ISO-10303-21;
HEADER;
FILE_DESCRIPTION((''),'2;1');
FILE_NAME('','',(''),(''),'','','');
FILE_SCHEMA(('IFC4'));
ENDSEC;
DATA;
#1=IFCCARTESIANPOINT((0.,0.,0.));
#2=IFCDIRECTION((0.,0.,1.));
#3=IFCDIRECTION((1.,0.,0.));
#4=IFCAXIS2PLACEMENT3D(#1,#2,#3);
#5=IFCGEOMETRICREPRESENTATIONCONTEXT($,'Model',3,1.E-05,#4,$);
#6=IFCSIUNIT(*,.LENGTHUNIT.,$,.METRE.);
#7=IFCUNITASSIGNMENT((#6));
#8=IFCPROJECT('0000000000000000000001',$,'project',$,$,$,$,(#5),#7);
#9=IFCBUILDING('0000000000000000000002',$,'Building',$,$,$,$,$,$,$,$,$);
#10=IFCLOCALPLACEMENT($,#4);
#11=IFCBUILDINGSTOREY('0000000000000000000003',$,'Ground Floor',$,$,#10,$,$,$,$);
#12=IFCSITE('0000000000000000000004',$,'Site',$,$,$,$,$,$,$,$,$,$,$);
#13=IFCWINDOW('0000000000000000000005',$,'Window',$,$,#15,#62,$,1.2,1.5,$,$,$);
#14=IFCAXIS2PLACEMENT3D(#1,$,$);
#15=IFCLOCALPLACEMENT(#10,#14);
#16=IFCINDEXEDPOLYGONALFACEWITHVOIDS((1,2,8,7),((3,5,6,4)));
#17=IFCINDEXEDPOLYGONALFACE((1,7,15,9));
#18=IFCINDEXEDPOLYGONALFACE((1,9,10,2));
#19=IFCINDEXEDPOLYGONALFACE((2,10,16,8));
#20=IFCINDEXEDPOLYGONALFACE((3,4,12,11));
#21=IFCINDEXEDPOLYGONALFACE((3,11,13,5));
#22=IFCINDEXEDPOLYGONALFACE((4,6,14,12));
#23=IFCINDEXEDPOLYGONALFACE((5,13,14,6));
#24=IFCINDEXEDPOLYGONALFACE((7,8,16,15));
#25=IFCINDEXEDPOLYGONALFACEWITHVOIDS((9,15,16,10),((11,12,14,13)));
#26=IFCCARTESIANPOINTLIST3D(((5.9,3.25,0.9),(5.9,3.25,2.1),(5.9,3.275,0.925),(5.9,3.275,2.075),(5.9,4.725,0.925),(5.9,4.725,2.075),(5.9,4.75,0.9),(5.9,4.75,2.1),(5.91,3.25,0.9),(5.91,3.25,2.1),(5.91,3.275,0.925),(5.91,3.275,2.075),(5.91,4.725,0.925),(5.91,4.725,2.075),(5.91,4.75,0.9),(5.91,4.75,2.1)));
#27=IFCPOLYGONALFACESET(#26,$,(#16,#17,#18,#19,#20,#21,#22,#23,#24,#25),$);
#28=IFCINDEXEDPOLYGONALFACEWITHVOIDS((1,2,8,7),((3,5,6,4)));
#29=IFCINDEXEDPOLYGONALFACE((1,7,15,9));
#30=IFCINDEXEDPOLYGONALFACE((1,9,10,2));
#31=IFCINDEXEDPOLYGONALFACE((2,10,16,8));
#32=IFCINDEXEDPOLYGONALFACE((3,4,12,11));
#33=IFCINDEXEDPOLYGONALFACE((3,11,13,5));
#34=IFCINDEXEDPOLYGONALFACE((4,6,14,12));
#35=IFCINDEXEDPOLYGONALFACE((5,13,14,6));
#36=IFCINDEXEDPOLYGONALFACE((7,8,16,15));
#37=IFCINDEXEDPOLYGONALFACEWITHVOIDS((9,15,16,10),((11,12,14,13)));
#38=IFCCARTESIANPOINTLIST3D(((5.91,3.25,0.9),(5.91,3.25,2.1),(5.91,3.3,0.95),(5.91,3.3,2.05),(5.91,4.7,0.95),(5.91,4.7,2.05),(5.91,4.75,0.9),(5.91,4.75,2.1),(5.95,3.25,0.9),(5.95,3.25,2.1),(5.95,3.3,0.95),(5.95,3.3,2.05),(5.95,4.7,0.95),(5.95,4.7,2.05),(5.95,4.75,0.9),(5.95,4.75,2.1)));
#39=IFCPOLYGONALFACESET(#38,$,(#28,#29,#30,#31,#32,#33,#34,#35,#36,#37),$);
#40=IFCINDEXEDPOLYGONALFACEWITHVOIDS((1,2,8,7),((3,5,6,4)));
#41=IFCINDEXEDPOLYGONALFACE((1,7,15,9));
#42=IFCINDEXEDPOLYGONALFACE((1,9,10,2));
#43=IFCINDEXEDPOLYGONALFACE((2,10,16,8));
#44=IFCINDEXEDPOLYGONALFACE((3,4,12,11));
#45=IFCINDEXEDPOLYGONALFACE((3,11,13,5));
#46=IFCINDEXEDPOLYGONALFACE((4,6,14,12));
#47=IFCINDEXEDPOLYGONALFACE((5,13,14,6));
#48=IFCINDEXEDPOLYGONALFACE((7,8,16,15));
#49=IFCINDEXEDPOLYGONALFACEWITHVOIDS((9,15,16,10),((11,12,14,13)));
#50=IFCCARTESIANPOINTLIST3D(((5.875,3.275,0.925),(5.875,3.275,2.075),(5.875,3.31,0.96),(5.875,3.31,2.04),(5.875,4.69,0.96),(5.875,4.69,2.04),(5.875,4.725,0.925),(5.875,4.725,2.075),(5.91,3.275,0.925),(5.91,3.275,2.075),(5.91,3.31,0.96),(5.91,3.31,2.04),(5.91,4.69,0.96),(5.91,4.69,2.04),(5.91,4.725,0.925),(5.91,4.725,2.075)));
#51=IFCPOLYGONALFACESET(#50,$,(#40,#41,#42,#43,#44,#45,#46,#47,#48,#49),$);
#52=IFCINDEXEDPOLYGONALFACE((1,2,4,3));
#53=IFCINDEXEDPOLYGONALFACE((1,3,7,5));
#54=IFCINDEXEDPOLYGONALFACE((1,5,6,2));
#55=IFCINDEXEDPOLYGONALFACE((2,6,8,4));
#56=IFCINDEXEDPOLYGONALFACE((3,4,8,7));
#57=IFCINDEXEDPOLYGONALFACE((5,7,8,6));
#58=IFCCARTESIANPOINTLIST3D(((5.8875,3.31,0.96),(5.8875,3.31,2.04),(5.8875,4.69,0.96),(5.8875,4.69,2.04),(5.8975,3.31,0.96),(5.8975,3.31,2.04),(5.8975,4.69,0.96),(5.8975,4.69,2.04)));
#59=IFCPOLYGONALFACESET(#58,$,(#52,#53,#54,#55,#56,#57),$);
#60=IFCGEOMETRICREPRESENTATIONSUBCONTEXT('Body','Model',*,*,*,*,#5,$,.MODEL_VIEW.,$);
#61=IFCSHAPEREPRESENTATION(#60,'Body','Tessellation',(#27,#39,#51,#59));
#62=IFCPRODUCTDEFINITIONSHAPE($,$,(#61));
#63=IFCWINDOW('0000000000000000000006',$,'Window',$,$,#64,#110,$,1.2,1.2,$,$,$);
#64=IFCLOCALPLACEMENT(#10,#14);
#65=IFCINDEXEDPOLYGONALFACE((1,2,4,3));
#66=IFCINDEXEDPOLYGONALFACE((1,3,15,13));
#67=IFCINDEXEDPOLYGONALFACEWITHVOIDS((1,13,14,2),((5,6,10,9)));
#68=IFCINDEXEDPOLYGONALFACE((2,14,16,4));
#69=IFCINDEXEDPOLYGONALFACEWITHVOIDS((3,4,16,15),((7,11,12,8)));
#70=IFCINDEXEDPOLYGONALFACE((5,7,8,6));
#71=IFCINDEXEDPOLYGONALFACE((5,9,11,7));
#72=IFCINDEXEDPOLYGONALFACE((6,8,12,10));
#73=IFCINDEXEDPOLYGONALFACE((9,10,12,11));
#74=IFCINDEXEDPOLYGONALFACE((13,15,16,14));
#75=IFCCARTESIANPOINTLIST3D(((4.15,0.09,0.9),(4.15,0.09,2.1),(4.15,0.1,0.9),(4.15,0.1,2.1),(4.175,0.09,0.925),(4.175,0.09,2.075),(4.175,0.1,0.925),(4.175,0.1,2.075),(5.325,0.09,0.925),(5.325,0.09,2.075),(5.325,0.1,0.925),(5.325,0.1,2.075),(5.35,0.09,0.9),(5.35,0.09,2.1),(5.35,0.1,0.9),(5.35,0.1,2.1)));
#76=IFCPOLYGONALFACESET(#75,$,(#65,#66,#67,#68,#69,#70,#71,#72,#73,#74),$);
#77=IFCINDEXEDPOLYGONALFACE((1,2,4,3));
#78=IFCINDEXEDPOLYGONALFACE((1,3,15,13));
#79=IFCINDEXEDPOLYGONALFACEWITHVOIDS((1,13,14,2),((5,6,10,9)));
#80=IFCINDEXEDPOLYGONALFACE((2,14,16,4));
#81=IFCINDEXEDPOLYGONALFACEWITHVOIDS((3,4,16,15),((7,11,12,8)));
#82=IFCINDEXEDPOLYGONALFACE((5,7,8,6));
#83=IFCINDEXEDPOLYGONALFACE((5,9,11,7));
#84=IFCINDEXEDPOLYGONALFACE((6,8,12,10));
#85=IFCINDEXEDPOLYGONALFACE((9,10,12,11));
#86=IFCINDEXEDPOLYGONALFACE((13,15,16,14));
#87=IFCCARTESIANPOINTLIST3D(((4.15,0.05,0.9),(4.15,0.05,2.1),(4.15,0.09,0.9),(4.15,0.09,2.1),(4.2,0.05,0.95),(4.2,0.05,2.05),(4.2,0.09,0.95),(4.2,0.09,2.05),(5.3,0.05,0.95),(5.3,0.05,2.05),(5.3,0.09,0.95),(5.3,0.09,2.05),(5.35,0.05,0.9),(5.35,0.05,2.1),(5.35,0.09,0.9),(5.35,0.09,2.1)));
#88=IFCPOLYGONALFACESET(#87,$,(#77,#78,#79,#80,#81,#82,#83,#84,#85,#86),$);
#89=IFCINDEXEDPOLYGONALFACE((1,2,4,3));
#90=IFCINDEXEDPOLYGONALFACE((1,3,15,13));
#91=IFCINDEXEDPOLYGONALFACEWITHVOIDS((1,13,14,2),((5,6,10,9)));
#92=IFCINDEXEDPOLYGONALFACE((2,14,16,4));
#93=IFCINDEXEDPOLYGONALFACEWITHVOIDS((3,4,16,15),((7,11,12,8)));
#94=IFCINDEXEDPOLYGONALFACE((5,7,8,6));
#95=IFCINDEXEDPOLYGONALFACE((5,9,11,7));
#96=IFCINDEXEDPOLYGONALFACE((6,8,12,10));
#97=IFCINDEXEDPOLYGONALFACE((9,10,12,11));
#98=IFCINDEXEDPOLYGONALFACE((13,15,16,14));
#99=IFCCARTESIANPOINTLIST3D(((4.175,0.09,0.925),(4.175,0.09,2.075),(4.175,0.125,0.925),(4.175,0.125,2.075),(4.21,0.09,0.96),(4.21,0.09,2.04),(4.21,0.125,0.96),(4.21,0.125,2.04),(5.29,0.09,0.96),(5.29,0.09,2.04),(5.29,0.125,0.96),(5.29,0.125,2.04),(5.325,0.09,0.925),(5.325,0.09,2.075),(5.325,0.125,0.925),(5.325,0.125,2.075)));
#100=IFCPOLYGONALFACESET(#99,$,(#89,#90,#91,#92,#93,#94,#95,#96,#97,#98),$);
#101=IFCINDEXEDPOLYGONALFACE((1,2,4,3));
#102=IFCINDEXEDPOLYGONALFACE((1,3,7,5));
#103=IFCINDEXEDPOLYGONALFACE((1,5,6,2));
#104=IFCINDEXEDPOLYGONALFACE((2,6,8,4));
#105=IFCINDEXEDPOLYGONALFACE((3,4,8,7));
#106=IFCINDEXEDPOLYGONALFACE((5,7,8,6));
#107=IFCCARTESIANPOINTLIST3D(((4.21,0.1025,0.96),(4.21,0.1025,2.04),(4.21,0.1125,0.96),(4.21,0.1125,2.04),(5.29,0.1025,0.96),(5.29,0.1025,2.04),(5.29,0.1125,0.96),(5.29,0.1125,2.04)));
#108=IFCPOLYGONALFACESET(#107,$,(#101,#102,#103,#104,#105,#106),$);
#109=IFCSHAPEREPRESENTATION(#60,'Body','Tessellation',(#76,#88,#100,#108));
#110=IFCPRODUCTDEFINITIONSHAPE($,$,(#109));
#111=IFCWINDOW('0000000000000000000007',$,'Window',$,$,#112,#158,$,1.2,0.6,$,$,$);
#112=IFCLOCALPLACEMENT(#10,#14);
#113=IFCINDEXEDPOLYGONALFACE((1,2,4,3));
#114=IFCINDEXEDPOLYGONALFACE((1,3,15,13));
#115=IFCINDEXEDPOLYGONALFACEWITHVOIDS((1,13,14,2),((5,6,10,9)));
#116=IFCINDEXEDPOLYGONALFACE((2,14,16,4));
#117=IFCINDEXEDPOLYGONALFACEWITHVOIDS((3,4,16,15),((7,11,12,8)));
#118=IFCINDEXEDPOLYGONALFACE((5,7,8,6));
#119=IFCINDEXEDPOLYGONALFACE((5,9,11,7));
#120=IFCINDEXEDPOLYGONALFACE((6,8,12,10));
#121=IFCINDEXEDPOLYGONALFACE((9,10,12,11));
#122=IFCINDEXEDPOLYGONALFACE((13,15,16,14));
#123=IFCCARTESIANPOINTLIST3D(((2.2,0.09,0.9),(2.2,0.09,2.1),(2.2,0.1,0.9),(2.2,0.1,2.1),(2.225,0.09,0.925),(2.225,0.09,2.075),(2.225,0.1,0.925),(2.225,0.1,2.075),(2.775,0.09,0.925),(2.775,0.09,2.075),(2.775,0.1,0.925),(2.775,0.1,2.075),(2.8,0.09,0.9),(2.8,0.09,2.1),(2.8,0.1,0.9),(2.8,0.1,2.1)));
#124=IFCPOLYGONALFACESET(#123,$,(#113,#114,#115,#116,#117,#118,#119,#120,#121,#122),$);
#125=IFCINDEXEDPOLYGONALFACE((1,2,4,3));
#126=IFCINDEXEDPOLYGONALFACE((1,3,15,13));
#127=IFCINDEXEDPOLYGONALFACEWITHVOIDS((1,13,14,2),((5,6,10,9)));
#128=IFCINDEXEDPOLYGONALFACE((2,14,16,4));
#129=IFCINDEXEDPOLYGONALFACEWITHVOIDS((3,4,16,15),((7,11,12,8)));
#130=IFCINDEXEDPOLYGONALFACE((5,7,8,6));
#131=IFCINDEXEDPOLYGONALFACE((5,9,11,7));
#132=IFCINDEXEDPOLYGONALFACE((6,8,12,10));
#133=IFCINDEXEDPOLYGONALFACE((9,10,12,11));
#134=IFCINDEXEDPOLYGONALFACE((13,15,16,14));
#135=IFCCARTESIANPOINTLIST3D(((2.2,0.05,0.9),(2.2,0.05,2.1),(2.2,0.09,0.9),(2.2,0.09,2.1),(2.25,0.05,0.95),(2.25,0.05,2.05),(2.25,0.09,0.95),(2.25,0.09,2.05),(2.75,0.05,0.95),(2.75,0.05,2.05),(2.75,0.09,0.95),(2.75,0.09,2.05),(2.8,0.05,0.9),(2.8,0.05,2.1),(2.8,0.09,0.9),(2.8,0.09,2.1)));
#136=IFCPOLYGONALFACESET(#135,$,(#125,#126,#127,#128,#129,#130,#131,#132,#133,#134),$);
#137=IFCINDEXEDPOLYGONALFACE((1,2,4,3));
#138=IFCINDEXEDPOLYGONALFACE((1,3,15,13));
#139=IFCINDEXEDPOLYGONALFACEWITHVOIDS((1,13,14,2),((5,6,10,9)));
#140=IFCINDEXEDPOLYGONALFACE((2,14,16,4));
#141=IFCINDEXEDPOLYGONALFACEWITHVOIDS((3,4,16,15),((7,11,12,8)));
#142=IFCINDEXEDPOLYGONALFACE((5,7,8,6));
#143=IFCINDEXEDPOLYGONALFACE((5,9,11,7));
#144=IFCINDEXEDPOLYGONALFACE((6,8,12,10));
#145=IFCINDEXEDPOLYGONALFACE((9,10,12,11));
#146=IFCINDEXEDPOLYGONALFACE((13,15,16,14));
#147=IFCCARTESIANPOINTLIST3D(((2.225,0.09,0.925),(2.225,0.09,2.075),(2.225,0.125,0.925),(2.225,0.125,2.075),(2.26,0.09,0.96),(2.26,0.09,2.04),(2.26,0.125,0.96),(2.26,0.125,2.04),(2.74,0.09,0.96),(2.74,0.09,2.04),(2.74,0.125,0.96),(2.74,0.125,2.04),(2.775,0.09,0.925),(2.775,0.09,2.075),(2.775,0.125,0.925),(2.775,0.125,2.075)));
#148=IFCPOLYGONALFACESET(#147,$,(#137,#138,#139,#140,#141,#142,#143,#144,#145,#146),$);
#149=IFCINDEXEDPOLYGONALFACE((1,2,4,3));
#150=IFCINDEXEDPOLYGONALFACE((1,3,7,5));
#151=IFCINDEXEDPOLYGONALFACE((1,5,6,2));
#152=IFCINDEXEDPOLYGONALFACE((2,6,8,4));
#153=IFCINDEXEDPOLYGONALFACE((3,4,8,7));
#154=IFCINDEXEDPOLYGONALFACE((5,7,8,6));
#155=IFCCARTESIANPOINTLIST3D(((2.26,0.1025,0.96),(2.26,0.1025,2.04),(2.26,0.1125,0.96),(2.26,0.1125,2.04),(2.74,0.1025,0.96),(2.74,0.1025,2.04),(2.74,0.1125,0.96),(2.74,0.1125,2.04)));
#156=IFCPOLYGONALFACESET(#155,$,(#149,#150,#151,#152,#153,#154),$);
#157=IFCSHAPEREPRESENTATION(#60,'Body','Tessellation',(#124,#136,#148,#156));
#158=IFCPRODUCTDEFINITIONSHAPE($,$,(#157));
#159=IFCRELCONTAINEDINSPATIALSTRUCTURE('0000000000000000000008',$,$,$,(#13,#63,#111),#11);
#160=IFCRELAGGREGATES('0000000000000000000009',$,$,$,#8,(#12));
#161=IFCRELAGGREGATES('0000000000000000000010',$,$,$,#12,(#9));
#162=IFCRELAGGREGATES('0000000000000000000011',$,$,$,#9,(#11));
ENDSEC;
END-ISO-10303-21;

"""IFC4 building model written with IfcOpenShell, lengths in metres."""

from ifc_helpers import new_model, si_unit, frame, origin_with_axes, place, context, subcontext, project, spatial, line, indexed_curve, outline, extrude, element, save


model = new_model("IFC4")

# Units and contexts
model_context = context("Model", 3, precision=1e-05, world=origin_with_axes())
body_context = subcontext(model_context, "Body", "Model", "MODEL_VIEW")
ifc_project = project(units=[si_unit("LENGTHUNIT", "METRE")], contexts=[model_context])

# Site, building, storey
site = spatial("IfcSite", under=ifc_project, Name="Site")
building = spatial("IfcBuilding", under=site, Name="Building")
storey_placement = place(None, origin_with_axes())
storey = spatial("IfcBuildingStorey", under=building, at=storey_placement, Name="Ground Floor")

# Windows
for number, where, z_axis, x_axis, name in (
    (1, (6.0, 3.25, 0.9), (0.0, 0.0, 1.0), (0.0, 1.0, 0.0), "Window"),
):
    element("IfcWindow", number, at=place(storey_placement, frame(where, z_axis=z_axis, x_axis=x_axis)), inside=storey, Name=name, OverallHeight=1.2, OverallWidth=1.5, context=body_context, shape_type="SweptSolid", body=[
        extrude(outline(indexed_curve([(0.0, 0.0), (1.5, 0.0), (1.5, 1.2), (0.0, 1.2)], segments=[line(1, 2, 3, 4, 1)]), holes=[indexed_curve([(0.025, 0.025), (1.475, 0.025), (1.475, 1.175), (0.025, 1.175)], segments=[line(1, 2, 3, 4, 1)])]), frame((0.0, 0.09, 0.0), z_axis=(0.0, -1.0, 0.0), x_axis=(1.0, 0.0, 0.0)), (0.0, 0.0, -1.0), 0.01),
        extrude(outline(indexed_curve([(0.0, 0.0), (1.5, 0.0), (1.5, 1.2), (0.0, 1.2)], segments=[line(1, 2, 3, 4, 1)]), holes=[indexed_curve([(0.05, 0.05), (1.45, 0.05), (1.45, 1.15), (0.05, 1.15)], segments=[line(1, 2, 3, 4, 1)])]), frame((0.0, 0.05, 0.0), z_axis=(0.0, -1.0, 0.0), x_axis=(1.0, 0.0, 0.0)), (0.0, 0.0, -1.0), 0.04),
        extrude(outline(indexed_curve([(0.0, 0.0), (1.45, 0.0), (1.45, 1.15), (0.0, 1.15)], segments=[line(1, 2, 3, 4, 1)]), holes=[indexed_curve([(0.035, 0.035), (1.415, 0.035), (1.415, 1.115), (0.035, 1.115)], segments=[line(1, 2, 3, 4, 1)])]), frame((0.025, 0.09, 0.025), z_axis=(0.0, -1.0, 0.0), x_axis=(1.0, 0.0, 0.0)), (0.0, 0.0, -1.0), 0.035),
        extrude(outline(indexed_curve([(0.035, 0.035), (1.415, 0.035), (1.415, 1.115), (0.035, 1.115)], segments=[line(1, 2, 3, 4, 1)])), frame((0.025, 0.1025, 0.025), z_axis=(0.0, -1.0, 0.0), x_axis=(1.0, 0.0, 0.0)), (0.0, 0.0, -1.0), 0.01),
    ])
window_1_placement = place(storey_placement, frame((4.15, 0.0, 0.9), z_axis=(0.0, 0.0, 1.0), x_axis=(1.0, 0.0, 0.0)))
element("IfcWindow", 2, at=window_1_placement, inside=storey, Name="Window", OverallHeight=1.2, OverallWidth=1.2, context=body_context, shape_type="SweptSolid", body=[
    extrude(outline(indexed_curve([(0.0, 0.0), (1.2, 0.0), (1.2, 1.2), (0.0, 1.2)], segments=[line(1, 2, 3, 4, 1)]), holes=[indexed_curve([(0.025, 0.025), (1.175, 0.025), (1.175, 1.175), (0.025, 1.175)], segments=[line(1, 2, 3, 4, 1)])]), frame((0.0, 0.09, 0.0), z_axis=(0.0, -1.0, 0.0), x_axis=(1.0, 0.0, 0.0)), (0.0, 0.0, -1.0), 0.01),
    extrude(outline(indexed_curve([(0.0, 0.0), (1.2, 0.0), (1.2, 1.2), (0.0, 1.2)], segments=[line(1, 2, 3, 4, 1)]), holes=[indexed_curve([(0.05, 0.05), (1.15, 0.05), (1.15, 1.15), (0.05, 1.15)], segments=[line(1, 2, 3, 4, 1)])]), frame((0.0, 0.05, 0.0), z_axis=(0.0, -1.0, 0.0), x_axis=(1.0, 0.0, 0.0)), (0.0, 0.0, -1.0), 0.04),
    extrude(outline(indexed_curve([(0.0, 0.0), (1.15, 0.0), (1.15, 1.15), (0.0, 1.15)], segments=[line(1, 2, 3, 4, 1)]), holes=[indexed_curve([(0.035, 0.035), (1.115, 0.035), (1.115, 1.115), (0.035, 1.115)], segments=[line(1, 2, 3, 4, 1)])]), frame((0.025, 0.09, 0.025), z_axis=(0.0, -1.0, 0.0), x_axis=(1.0, 0.0, 0.0)), (0.0, 0.0, -1.0), 0.035),
    extrude(outline(indexed_curve([(0.035, 0.035), (1.115, 0.035), (1.115, 1.115), (0.035, 1.115)], segments=[line(1, 2, 3, 4, 1)])), frame((0.025, 0.1025, 0.025), z_axis=(0.0, -1.0, 0.0), x_axis=(1.0, 0.0, 0.0)), (0.0, 0.0, -1.0), 0.01),
])
window_2_placement = place(storey_placement, frame((2.2, 0.0, 0.9), z_axis=(0.0, 0.0, 1.0), x_axis=(1.0, 0.0, 0.0)))
element("IfcWindow", 3, at=window_2_placement, inside=storey, Name="Window", OverallHeight=1.2, OverallWidth=0.6, context=body_context, shape_type="SweptSolid", body=[
    extrude(outline(indexed_curve([(0.0, 0.0), (0.6, 0.0), (0.6, 1.2), (0.0, 1.2)], segments=[line(1, 2, 3, 4, 1)]), holes=[indexed_curve([(0.025, 0.025), (0.575, 0.025), (0.575, 1.175), (0.025, 1.175)], segments=[line(1, 2, 3, 4, 1)])]), frame((0.0, 0.09, 0.0), z_axis=(0.0, -1.0, 0.0), x_axis=(1.0, 0.0, 0.0)), (0.0, 0.0, -1.0), 0.01),
    extrude(outline(indexed_curve([(0.0, 0.0), (0.6, 0.0), (0.6, 1.2), (0.0, 1.2)], segments=[line(1, 2, 3, 4, 1)]), holes=[indexed_curve([(0.05, 0.05), (0.55, 0.05), (0.55, 1.15), (0.05, 1.15)], segments=[line(1, 2, 3, 4, 1)])]), frame((0.0, 0.05, 0.0), z_axis=(0.0, -1.0, 0.0), x_axis=(1.0, 0.0, 0.0)), (0.0, 0.0, -1.0), 0.04),
    extrude(outline(indexed_curve([(0.0, 0.0), (0.55, 0.0), (0.55, 1.15), (0.0, 1.15)], segments=[line(1, 2, 3, 4, 1)]), holes=[indexed_curve([(0.035, 0.035), (0.515, 0.035), (0.515, 1.115), (0.035, 1.115)], segments=[line(1, 2, 3, 4, 1)])]), frame((0.025, 0.09, 0.025), z_axis=(0.0, -1.0, 0.0), x_axis=(1.0, 0.0, 0.0)), (0.0, 0.0, -1.0), 0.035),
    extrude(outline(indexed_curve([(0.035, 0.035), (0.515, 0.035), (0.515, 1.115), (0.035, 1.115)], segments=[line(1, 2, 3, 4, 1)])), frame((0.025, 0.1025, 0.025), z_axis=(0.0, -1.0, 0.0), x_axis=(1.0, 0.0, 0.0)), (0.0, 0.0, -1.0), 0.01),
])

save(model, "model.ifc")
